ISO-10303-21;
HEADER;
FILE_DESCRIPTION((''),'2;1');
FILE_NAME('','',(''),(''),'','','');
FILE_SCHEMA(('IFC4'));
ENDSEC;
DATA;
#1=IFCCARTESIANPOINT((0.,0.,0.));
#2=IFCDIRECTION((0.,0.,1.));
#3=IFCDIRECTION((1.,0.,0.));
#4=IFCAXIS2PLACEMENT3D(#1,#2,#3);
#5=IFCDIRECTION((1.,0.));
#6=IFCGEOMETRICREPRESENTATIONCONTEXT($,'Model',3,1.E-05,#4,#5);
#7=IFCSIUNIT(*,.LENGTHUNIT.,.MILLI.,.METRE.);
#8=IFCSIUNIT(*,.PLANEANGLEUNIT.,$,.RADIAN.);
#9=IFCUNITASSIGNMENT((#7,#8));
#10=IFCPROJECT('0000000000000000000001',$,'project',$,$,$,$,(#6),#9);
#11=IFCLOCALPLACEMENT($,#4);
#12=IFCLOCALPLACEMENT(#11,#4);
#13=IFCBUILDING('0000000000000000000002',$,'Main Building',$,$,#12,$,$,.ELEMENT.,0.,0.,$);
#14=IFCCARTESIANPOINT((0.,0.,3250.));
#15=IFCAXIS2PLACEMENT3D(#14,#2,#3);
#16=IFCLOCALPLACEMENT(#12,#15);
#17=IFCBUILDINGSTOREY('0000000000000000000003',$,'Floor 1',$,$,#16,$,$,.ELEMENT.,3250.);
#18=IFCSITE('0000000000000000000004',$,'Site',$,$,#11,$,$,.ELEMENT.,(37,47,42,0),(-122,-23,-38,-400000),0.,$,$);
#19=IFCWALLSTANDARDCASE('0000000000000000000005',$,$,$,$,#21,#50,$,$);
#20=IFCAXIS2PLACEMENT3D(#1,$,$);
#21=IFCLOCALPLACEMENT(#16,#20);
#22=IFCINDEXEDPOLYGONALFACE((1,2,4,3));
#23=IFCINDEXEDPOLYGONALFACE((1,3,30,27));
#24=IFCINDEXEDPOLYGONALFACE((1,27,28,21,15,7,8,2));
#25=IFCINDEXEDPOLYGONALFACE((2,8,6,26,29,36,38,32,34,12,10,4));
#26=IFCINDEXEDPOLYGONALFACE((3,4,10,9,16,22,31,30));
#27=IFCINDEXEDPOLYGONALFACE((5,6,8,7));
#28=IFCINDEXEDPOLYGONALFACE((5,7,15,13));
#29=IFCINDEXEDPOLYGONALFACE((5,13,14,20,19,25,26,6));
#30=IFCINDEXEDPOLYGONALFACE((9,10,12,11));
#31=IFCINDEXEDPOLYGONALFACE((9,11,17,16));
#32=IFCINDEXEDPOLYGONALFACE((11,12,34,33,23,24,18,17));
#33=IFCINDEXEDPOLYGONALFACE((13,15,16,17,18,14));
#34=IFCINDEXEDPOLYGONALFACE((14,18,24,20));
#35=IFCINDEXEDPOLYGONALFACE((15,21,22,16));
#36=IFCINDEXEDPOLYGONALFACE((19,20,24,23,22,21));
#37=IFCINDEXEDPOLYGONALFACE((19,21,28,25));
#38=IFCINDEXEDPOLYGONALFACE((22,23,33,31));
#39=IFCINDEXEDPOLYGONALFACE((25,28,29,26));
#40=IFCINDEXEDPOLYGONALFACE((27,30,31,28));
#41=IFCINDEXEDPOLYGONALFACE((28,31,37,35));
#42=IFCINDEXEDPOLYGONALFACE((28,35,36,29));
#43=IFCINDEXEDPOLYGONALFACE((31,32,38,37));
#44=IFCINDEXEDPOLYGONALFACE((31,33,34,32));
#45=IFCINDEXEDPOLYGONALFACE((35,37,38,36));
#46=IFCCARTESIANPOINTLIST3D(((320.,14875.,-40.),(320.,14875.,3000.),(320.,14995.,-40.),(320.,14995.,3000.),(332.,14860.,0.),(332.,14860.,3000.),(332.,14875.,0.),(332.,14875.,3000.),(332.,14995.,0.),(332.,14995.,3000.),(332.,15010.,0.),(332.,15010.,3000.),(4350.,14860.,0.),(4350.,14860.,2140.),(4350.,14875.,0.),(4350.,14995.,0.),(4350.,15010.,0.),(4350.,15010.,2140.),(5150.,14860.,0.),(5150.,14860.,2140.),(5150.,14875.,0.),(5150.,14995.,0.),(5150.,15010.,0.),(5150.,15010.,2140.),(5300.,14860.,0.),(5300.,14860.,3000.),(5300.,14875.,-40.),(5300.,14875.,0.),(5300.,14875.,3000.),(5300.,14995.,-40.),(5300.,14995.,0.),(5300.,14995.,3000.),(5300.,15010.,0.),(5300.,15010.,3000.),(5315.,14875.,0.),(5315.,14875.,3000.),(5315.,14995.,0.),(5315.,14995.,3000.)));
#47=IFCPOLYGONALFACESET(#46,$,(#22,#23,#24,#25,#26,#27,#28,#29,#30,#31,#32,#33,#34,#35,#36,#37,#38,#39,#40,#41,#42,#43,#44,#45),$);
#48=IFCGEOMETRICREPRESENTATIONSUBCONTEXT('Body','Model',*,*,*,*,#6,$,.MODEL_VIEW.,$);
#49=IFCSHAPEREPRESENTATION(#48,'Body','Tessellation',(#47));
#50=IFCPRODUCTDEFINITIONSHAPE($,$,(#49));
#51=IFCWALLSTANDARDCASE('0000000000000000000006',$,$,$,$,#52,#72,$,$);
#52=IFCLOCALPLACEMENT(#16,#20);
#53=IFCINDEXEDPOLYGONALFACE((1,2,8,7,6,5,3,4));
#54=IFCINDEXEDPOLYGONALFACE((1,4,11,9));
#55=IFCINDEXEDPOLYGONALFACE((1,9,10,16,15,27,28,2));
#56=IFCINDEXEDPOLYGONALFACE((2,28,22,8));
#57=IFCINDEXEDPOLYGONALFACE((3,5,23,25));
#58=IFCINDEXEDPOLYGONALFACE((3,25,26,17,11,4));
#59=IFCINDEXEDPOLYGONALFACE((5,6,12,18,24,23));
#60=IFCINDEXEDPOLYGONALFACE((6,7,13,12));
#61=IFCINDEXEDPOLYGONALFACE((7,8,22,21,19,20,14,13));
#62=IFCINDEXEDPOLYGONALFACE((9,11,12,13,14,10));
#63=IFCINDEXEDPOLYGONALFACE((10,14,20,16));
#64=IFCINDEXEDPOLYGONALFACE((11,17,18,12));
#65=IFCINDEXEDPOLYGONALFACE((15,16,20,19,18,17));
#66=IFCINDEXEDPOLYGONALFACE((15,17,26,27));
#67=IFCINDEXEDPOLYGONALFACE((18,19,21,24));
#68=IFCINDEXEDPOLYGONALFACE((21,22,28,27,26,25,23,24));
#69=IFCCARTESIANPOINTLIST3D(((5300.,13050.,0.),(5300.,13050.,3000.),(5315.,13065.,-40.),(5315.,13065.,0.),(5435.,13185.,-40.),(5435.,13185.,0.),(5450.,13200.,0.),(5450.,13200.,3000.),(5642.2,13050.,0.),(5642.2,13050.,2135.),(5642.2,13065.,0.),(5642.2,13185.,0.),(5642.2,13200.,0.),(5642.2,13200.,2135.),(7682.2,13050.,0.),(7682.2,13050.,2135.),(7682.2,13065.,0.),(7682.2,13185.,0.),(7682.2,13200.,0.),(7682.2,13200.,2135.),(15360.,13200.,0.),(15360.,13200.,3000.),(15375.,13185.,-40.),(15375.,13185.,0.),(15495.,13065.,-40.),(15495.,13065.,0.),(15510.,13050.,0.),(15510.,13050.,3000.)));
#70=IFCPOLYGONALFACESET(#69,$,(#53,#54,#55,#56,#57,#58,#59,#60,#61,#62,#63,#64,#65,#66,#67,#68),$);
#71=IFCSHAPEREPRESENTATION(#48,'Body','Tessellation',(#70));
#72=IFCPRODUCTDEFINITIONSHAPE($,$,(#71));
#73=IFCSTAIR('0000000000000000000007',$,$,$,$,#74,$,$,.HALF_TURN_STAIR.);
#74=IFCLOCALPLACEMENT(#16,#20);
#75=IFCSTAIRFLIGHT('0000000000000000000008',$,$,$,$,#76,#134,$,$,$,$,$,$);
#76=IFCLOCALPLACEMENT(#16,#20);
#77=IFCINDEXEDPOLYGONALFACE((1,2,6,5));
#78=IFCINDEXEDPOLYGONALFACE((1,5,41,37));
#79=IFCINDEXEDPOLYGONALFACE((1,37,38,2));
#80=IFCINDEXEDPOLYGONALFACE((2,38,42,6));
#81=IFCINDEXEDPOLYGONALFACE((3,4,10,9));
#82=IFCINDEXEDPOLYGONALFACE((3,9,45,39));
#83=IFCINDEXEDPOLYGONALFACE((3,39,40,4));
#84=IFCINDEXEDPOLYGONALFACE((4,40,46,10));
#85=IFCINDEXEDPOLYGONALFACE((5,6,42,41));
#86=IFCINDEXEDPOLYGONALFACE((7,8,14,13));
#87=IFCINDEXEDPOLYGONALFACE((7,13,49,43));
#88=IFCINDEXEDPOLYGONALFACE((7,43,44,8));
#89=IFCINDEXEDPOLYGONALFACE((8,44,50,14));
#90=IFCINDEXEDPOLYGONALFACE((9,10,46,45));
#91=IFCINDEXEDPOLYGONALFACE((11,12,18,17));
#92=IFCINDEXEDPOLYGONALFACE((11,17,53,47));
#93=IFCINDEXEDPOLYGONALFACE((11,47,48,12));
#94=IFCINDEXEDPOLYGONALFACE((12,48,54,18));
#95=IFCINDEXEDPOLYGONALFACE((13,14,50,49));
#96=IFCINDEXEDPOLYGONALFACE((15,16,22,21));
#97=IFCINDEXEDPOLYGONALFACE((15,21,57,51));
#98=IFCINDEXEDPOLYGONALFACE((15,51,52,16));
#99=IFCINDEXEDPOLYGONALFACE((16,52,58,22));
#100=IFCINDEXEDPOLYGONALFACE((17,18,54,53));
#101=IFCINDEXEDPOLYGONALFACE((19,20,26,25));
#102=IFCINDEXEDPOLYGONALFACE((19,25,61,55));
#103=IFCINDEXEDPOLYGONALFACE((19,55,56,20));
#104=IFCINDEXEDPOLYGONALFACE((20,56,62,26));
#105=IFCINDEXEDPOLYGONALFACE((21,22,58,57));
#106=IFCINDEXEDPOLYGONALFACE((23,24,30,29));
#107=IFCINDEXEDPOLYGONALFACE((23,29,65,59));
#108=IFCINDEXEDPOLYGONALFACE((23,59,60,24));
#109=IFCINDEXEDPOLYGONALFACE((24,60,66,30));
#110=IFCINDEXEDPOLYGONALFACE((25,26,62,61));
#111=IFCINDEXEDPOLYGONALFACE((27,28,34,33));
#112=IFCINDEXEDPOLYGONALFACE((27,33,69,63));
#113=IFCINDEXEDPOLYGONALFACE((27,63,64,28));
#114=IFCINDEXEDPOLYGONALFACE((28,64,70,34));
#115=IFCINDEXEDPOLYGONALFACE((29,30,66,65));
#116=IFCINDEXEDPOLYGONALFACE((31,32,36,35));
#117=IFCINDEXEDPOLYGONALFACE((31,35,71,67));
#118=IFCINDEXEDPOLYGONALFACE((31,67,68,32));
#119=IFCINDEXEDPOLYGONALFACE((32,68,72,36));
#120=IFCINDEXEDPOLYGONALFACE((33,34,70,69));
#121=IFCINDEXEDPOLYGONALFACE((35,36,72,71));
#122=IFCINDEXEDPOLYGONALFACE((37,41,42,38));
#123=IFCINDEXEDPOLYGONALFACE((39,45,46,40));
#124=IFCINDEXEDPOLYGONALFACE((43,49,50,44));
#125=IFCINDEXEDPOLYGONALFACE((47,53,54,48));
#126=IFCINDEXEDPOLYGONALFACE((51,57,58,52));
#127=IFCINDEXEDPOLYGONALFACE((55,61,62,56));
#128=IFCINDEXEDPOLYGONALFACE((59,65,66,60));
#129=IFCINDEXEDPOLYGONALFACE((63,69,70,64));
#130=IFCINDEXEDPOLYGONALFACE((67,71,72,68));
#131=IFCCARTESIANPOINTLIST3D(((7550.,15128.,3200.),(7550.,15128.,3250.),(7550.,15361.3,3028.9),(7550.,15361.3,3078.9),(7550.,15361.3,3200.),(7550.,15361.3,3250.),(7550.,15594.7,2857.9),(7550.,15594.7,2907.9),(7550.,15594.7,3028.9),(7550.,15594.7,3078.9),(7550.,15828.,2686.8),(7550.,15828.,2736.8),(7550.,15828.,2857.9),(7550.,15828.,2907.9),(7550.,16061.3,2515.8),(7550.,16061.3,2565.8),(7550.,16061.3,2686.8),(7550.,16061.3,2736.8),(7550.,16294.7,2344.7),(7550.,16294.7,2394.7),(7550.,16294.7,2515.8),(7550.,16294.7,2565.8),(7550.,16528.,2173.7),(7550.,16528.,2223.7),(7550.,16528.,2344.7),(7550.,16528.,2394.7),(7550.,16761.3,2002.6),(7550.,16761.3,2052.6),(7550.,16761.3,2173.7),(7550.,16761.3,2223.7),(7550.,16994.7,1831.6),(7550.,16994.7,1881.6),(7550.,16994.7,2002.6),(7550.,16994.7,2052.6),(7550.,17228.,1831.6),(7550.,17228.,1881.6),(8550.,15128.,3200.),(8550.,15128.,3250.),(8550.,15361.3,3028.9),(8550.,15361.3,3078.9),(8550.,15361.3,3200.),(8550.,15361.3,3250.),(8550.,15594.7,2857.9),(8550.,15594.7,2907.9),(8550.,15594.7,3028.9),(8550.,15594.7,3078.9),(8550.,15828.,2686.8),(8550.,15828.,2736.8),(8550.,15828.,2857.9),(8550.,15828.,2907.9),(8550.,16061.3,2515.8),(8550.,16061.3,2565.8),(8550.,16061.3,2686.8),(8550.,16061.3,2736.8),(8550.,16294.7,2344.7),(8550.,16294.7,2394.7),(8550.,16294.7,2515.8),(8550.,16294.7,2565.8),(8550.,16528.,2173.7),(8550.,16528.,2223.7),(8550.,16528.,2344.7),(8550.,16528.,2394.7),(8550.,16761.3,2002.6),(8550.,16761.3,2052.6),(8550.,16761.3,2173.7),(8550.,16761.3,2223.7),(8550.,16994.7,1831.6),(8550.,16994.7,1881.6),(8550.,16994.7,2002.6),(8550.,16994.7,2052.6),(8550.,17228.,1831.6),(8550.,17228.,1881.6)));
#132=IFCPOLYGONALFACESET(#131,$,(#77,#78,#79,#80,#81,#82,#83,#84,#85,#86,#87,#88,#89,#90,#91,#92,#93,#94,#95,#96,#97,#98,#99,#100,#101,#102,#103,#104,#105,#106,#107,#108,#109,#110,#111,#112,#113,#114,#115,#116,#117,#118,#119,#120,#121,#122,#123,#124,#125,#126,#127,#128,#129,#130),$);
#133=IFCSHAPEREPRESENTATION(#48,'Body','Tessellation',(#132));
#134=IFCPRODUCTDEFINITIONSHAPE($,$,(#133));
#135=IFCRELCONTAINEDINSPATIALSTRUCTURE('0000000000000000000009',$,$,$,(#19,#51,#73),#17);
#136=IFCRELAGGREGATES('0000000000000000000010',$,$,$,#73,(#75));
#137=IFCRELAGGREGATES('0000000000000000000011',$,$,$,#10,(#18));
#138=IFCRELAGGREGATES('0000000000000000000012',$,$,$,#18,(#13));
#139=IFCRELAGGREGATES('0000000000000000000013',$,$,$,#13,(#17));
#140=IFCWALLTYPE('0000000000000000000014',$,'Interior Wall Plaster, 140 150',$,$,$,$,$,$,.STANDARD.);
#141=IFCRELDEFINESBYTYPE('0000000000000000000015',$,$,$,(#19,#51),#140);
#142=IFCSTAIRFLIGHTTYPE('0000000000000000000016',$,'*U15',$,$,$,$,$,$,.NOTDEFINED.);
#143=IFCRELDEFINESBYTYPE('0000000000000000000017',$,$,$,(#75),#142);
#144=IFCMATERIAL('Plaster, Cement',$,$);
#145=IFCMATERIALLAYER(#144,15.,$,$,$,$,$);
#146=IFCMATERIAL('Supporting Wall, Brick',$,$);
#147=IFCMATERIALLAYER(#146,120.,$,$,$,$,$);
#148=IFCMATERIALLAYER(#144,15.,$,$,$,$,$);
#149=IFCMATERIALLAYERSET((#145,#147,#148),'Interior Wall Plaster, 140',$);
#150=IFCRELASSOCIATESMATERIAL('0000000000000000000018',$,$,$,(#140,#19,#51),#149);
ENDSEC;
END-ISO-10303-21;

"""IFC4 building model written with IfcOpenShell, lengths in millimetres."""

from ifc_helpers import new_model, si_unit, direction, frame, frame_2d, origin_with_axes, place, context, subcontext, project, spatial, polyline, rectangle, outline, extrude, clip, bounded_halfspace, source, transform, mapped, material, layer, layer_set, layer_usage, type_object, type_shapes, element, aggregate, save


model = new_model("IFC4")

# Units and contexts
model_context = context("Model", 3, precision=1e-05, world=origin_with_axes(), true_north=direction((1.0, 0.0)))
body_context = subcontext(model_context, "Body", "Model", "MODEL_VIEW")
ifc_project = project(units=[si_unit("LENGTHUNIT", "METRE", prefix="MILLI"), si_unit("PLANEANGLEUNIT", "RADIAN")], contexts=[model_context])

# Site, building, storey
site_placement = place(None, origin_with_axes())
site = spatial("IfcSite", under=ifc_project, at=site_placement, Name="Site", CompositionType="ELEMENT", RefLatitude=(37, 47, 42, 0), RefLongitude=(-122, -23, -38, -400000), RefElevation=0.0)
building_placement = place(site_placement, origin_with_axes())
building = spatial("IfcBuilding", under=site, at=building_placement, Name="Main Building", CompositionType="ELEMENT", ElevationOfRefHeight=0.0, ElevationOfTerrain=0.0)
storey_placement = place(building_placement, frame((0.0, 0.0, 3250.0), z_axis=(0.0, 0.0, 1.0), x_axis=(1.0, 0.0, 0.0)))
storey = spatial("IfcBuildingStorey", under=building, at=storey_placement, Name="Floor 1", CompositionType="ELEMENT", Elevation=3250.0)

# Shared definitions
ifc_material_1 = material(Name="Supporting Wall, Brick")

# Shared definitions
ifc_material_2 = material(Name="Plaster, Cement")
ifc_layer_1 = layer(ifc_material_2, 15.0)
ifc_layer_2 = layer(ifc_material_1, 120.0)
ifc_layer_3 = layer(ifc_material_2, 15.0)
ifc_layer_set_1 = layer_set([ifc_layer_1, ifc_layer_2, ifc_layer_3], Name="Interior Wall Plaster, 140")
wall_type_1 = type_object("IfcWallType", Name="Interior Wall Plaster, 140 150", PredefinedType="STANDARD", material=ifc_layer_set_1)

# Wall, opening
ifc_layer_usage_1 = layer_usage(ifc_layer_set_1, "AXIS2", "POSITIVE", 0.0)
wall_1_placement = place(storey_placement, frame((320.0, 14860.0, -40.0), z_axis=(0.0, 0.0, 1.0), x_axis=(1.0, 0.0, 0.0)))
wall_1 = element("IfcWallStandardCase", 1, at=wall_1_placement, inside=storey, type_object=wall_type_1, material=ifc_layer_usage_1, context=body_context, shape_type="Clipping", body=[
    clip(clip(clip(extrude(outline(polyline([(2483.5, 75.0), (2483.5, 60.0), (2498.5, 60.0), (2498.5, -60.0), (2483.5, -60.0), (2483.5, -75.0), (-2484.5, -75.0), (-2484.5, -60.0), (-2496.5, -60.0), (-2496.5, 60.0), (-2484.5, 60.0), (-2484.5, 75.0), (2483.5, 75.0)])), frame((2496.5, 75.0, 0.0), z_axis=(0.0, 0.0, 1.0), x_axis=(1.0, 0.0, 0.0)), (0.0, 0.0, 1.0), 3040.0), bounded_halfspace(frame((-320.0, -14860.0, 40.0), z_axis=(0.0, 0.0, -1.0), x_axis=(-1.0, 0.0, 0.0)), False, frame((2496.5, 75.0, 0.0), z_axis=(0.0, 0.0, 1.0), x_axis=(1.0, 0.0, 0.0)), polyline([(-2484.5, 75.0), (2483.5, 75.0), (2483.5, 60.0), (-2484.5, 60.0), (-2484.5, 75.0)]))), bounded_halfspace(frame((-320.0, -14860.0, 40.0), z_axis=(0.0, 0.0, -1.0), x_axis=(-1.0, 0.0, 0.0)), False, frame((2496.5, 75.0, 0.0), z_axis=(0.0, 0.0, 1.0), x_axis=(1.0, 0.0, 0.0)), polyline([(-2484.5, -60.0), (2483.5, -60.0), (2483.5, -75.0), (-2484.5, -75.0), (-2484.5, -60.0)]))), bounded_halfspace(frame((-320.0, -14860.0, 40.0), z_axis=(0.0, 0.0, -1.0), x_axis=(-1.0, 0.0, 0.0)), False, frame((2496.5, 75.0, 0.0), z_axis=(0.0, 0.0, 1.0), x_axis=(1.0, 0.0, 0.0)), polyline([(2498.5, -60.0), (2483.5, -60.0), (2483.5, 60.0), (2498.5, 60.0), (2498.5, -60.0)]))),
])
opening_1_placement = place(wall_1_placement, frame((4830.0, 150.0, 40.0), z_axis=(0.0, 0.0, 1.0), x_axis=(-1.0, 0.0, 0.0)))
element("IfcOpeningElement", 2, at=opening_1_placement, cuts=wall_1, ObjectType="Opening", context=body_context, shape_type="SweptSolid", body=[
    extrude(outline(polyline([(-400.0, 1070.0), (400.0, 1070.0), (400.0, -1070.0), (-400.0, -1070.0), (-400.0, 1070.0)])), frame((400.0, 0.0, 1070.0), z_axis=(0.0, 1.0, 0.0), x_axis=(1.0, 0.0, 0.0)), (0.0, 0.0, 1.0), 1000.0),
])

# Wall, opening
ifc_layer_usage_2 = layer_usage(ifc_layer_set_1, "AXIS2", "POSITIVE", 0.0)
wall_2_placement = place(storey_placement, frame((5300.0, 13050.0, -40.0), z_axis=(0.0, 0.0, 1.0), x_axis=(1.0, 0.0, 0.0)))
wall_2 = element("IfcWallStandardCase", 3, at=wall_2_placement, inside=storey, type_object=wall_type_1, material=ifc_layer_usage_2, context=body_context, shape_type="Clipping", body=[
    clip(clip(extrude(outline(polyline([(5105.0, -75.0), (-5105.0, -75.0), (-4955.0, 75.0), (4955.0, 75.0), (5105.0, -75.0)])), frame((5105.0, 75.0, 0.0), z_axis=(0.0, 0.0, 1.0), x_axis=(1.0, 0.0, 0.0)), (0.0, 0.0, 1.0), 3040.0), bounded_halfspace(frame((-5300.0, -13050.0, 40.0), z_axis=(0.0, 0.0, -1.0), x_axis=(-1.0, 0.0, 0.0)), False, frame((5105.0, 75.0, 0.0), z_axis=(0.0, 0.0, 1.0), x_axis=(1.0, 0.0, 0.0)), polyline([(5105.0, -75.0), (-5105.0, -75.0), (-5090.0, -60.0), (5090.0, -60.0), (5105.0, -75.0)]))), bounded_halfspace(frame((-5300.0, -13050.0, 40.0), z_axis=(0.0, 0.0, -1.0), x_axis=(-1.0, 0.0, 0.0)), False, frame((5105.0, 75.0, 0.0), z_axis=(0.0, 0.0, 1.0), x_axis=(1.0, 0.0, 0.0)), polyline([(4970.0, 60.0), (-4970.0, 60.0), (-4955.0, 75.0), (4955.0, 75.0), (4970.0, 60.0)]))),
])
opening_2_placement = place(wall_2_placement, frame((2382.2, 150.0, 40.0), z_axis=(0.0, 0.0, 1.0), x_axis=(-1.0, 0.0, 0.0)))
element("IfcOpeningElement", 4, at=opening_2_placement, cuts=wall_2, ObjectType="Opening", context=body_context, shape_type="SweptSolid", body=[
    extrude(outline(polyline([(-1020.0, -1067.5), (-1020.0, 1067.5), (1020.0, 1067.5), (1020.0, -1067.5), (-1020.0, -1067.5)])), frame((1020.0, 0.0, 1067.5), z_axis=(0.0, 1.0, 0.0), x_axis=(1.0, 0.0, 0.0)), (0.0, 0.0, 1.0), 1000.0),
])

# Stair, stair flight
stair_placement = place(storey_placement, frame((8550.0, 15128.0, 3250.0), z_axis=(0.0, 0.0, 1.0), x_axis=(0.0, 1.0, 0.0)))
stair = element("IfcStair", 5, at=stair_placement, inside=storey, PredefinedType="HALF_TURN_STAIR")
stair_flight_type_1 = type_object("IfcStairFlightType", Name="*U15", PredefinedType="NOTDEFINED")
shared_shape_1 = source(origin_with_axes(), body_context, "Body", "SweptSolid", [
    extrude(rectangle(XDim=1000.0, YDim=233.3, at=frame_2d((0.0, 0.0), x_axis=(0.0, 1.0))), frame((116.7, 500.0, -50.0), z_axis=(0.0, 0.0, 1.0), x_axis=(1.0, 0.0, 0.0)), (0.0, 0.0, 1.0), 50.0),
])
shared_shape_2 = source(origin_with_axes(), body_context, "Body", "MappedRepresentation", [
    mapped(shared_shape_1, transform((0.0, 0.0, 0.0), x_axis=(1.0, 0.0, 0.0), y_axis=(0.0, 1.0, 0.0), z_axis=(0.0, 0.0, 1.0), scale=1.0)),
    mapped(shared_shape_1, transform((233.3, 0.0, -171.1), x_axis=(1.0, 0.0, 0.0), y_axis=(0.0, 1.0, 0.0), z_axis=(0.0, 0.0, 1.0), scale=1.0)),
    mapped(shared_shape_1, transform((466.7, 0.0, -342.1), x_axis=(1.0, 0.0, 0.0), y_axis=(0.0, 1.0, 0.0), z_axis=(0.0, 0.0, 1.0), scale=1.0)),
    mapped(shared_shape_1, transform((700.0, 0.0, -513.2), x_axis=(1.0, 0.0, 0.0), y_axis=(0.0, 1.0, 0.0), z_axis=(0.0, 0.0, 1.0), scale=1.0)),
    mapped(shared_shape_1, transform((933.3, 0.0, -684.2), x_axis=(1.0, 0.0, 0.0), y_axis=(0.0, 1.0, 0.0), z_axis=(0.0, 0.0, 1.0), scale=1.0)),
    mapped(shared_shape_1, transform((1166.7, 0.0, -855.3), x_axis=(1.0, 0.0, 0.0), y_axis=(0.0, 1.0, 0.0), z_axis=(0.0, 0.0, 1.0), scale=1.0)),
    mapped(shared_shape_1, transform((1400.0, 0.0, -1026.3), x_axis=(1.0, 0.0, 0.0), y_axis=(0.0, 1.0, 0.0), z_axis=(0.0, 0.0, 1.0), scale=1.0)),
    mapped(shared_shape_1, transform((1633.3, 0.0, -1197.4), x_axis=(1.0, 0.0, 0.0), y_axis=(0.0, 1.0, 0.0), z_axis=(0.0, 0.0, 1.0), scale=1.0)),
    mapped(shared_shape_1, transform((1866.7, 0.0, -1368.4), x_axis=(1.0, 0.0, 0.0), y_axis=(0.0, 1.0, 0.0), z_axis=(0.0, 0.0, 1.0), scale=1.0)),
])
type_shapes(stair_flight_type_1, [shared_shape_2])
stair_flight_1_placement = place(stair_placement, origin_with_axes())
stair_flight_1 = element("IfcStairFlight", 6, at=stair_flight_1_placement, type_object=stair_flight_type_1, context=body_context, shape_type="MappedRepresentation", body=[
    mapped(shared_shape_2, transform((0.0, 0.0, 0.0), x_axis=(1.0, 0.0, 0.0), y_axis=(0.0, 1.0, 0.0), z_axis=(0.0, 0.0, 1.0), scale=1.0)),
])

aggregate(stair, [stair_flight_1])

save(model, "model.ifc")
